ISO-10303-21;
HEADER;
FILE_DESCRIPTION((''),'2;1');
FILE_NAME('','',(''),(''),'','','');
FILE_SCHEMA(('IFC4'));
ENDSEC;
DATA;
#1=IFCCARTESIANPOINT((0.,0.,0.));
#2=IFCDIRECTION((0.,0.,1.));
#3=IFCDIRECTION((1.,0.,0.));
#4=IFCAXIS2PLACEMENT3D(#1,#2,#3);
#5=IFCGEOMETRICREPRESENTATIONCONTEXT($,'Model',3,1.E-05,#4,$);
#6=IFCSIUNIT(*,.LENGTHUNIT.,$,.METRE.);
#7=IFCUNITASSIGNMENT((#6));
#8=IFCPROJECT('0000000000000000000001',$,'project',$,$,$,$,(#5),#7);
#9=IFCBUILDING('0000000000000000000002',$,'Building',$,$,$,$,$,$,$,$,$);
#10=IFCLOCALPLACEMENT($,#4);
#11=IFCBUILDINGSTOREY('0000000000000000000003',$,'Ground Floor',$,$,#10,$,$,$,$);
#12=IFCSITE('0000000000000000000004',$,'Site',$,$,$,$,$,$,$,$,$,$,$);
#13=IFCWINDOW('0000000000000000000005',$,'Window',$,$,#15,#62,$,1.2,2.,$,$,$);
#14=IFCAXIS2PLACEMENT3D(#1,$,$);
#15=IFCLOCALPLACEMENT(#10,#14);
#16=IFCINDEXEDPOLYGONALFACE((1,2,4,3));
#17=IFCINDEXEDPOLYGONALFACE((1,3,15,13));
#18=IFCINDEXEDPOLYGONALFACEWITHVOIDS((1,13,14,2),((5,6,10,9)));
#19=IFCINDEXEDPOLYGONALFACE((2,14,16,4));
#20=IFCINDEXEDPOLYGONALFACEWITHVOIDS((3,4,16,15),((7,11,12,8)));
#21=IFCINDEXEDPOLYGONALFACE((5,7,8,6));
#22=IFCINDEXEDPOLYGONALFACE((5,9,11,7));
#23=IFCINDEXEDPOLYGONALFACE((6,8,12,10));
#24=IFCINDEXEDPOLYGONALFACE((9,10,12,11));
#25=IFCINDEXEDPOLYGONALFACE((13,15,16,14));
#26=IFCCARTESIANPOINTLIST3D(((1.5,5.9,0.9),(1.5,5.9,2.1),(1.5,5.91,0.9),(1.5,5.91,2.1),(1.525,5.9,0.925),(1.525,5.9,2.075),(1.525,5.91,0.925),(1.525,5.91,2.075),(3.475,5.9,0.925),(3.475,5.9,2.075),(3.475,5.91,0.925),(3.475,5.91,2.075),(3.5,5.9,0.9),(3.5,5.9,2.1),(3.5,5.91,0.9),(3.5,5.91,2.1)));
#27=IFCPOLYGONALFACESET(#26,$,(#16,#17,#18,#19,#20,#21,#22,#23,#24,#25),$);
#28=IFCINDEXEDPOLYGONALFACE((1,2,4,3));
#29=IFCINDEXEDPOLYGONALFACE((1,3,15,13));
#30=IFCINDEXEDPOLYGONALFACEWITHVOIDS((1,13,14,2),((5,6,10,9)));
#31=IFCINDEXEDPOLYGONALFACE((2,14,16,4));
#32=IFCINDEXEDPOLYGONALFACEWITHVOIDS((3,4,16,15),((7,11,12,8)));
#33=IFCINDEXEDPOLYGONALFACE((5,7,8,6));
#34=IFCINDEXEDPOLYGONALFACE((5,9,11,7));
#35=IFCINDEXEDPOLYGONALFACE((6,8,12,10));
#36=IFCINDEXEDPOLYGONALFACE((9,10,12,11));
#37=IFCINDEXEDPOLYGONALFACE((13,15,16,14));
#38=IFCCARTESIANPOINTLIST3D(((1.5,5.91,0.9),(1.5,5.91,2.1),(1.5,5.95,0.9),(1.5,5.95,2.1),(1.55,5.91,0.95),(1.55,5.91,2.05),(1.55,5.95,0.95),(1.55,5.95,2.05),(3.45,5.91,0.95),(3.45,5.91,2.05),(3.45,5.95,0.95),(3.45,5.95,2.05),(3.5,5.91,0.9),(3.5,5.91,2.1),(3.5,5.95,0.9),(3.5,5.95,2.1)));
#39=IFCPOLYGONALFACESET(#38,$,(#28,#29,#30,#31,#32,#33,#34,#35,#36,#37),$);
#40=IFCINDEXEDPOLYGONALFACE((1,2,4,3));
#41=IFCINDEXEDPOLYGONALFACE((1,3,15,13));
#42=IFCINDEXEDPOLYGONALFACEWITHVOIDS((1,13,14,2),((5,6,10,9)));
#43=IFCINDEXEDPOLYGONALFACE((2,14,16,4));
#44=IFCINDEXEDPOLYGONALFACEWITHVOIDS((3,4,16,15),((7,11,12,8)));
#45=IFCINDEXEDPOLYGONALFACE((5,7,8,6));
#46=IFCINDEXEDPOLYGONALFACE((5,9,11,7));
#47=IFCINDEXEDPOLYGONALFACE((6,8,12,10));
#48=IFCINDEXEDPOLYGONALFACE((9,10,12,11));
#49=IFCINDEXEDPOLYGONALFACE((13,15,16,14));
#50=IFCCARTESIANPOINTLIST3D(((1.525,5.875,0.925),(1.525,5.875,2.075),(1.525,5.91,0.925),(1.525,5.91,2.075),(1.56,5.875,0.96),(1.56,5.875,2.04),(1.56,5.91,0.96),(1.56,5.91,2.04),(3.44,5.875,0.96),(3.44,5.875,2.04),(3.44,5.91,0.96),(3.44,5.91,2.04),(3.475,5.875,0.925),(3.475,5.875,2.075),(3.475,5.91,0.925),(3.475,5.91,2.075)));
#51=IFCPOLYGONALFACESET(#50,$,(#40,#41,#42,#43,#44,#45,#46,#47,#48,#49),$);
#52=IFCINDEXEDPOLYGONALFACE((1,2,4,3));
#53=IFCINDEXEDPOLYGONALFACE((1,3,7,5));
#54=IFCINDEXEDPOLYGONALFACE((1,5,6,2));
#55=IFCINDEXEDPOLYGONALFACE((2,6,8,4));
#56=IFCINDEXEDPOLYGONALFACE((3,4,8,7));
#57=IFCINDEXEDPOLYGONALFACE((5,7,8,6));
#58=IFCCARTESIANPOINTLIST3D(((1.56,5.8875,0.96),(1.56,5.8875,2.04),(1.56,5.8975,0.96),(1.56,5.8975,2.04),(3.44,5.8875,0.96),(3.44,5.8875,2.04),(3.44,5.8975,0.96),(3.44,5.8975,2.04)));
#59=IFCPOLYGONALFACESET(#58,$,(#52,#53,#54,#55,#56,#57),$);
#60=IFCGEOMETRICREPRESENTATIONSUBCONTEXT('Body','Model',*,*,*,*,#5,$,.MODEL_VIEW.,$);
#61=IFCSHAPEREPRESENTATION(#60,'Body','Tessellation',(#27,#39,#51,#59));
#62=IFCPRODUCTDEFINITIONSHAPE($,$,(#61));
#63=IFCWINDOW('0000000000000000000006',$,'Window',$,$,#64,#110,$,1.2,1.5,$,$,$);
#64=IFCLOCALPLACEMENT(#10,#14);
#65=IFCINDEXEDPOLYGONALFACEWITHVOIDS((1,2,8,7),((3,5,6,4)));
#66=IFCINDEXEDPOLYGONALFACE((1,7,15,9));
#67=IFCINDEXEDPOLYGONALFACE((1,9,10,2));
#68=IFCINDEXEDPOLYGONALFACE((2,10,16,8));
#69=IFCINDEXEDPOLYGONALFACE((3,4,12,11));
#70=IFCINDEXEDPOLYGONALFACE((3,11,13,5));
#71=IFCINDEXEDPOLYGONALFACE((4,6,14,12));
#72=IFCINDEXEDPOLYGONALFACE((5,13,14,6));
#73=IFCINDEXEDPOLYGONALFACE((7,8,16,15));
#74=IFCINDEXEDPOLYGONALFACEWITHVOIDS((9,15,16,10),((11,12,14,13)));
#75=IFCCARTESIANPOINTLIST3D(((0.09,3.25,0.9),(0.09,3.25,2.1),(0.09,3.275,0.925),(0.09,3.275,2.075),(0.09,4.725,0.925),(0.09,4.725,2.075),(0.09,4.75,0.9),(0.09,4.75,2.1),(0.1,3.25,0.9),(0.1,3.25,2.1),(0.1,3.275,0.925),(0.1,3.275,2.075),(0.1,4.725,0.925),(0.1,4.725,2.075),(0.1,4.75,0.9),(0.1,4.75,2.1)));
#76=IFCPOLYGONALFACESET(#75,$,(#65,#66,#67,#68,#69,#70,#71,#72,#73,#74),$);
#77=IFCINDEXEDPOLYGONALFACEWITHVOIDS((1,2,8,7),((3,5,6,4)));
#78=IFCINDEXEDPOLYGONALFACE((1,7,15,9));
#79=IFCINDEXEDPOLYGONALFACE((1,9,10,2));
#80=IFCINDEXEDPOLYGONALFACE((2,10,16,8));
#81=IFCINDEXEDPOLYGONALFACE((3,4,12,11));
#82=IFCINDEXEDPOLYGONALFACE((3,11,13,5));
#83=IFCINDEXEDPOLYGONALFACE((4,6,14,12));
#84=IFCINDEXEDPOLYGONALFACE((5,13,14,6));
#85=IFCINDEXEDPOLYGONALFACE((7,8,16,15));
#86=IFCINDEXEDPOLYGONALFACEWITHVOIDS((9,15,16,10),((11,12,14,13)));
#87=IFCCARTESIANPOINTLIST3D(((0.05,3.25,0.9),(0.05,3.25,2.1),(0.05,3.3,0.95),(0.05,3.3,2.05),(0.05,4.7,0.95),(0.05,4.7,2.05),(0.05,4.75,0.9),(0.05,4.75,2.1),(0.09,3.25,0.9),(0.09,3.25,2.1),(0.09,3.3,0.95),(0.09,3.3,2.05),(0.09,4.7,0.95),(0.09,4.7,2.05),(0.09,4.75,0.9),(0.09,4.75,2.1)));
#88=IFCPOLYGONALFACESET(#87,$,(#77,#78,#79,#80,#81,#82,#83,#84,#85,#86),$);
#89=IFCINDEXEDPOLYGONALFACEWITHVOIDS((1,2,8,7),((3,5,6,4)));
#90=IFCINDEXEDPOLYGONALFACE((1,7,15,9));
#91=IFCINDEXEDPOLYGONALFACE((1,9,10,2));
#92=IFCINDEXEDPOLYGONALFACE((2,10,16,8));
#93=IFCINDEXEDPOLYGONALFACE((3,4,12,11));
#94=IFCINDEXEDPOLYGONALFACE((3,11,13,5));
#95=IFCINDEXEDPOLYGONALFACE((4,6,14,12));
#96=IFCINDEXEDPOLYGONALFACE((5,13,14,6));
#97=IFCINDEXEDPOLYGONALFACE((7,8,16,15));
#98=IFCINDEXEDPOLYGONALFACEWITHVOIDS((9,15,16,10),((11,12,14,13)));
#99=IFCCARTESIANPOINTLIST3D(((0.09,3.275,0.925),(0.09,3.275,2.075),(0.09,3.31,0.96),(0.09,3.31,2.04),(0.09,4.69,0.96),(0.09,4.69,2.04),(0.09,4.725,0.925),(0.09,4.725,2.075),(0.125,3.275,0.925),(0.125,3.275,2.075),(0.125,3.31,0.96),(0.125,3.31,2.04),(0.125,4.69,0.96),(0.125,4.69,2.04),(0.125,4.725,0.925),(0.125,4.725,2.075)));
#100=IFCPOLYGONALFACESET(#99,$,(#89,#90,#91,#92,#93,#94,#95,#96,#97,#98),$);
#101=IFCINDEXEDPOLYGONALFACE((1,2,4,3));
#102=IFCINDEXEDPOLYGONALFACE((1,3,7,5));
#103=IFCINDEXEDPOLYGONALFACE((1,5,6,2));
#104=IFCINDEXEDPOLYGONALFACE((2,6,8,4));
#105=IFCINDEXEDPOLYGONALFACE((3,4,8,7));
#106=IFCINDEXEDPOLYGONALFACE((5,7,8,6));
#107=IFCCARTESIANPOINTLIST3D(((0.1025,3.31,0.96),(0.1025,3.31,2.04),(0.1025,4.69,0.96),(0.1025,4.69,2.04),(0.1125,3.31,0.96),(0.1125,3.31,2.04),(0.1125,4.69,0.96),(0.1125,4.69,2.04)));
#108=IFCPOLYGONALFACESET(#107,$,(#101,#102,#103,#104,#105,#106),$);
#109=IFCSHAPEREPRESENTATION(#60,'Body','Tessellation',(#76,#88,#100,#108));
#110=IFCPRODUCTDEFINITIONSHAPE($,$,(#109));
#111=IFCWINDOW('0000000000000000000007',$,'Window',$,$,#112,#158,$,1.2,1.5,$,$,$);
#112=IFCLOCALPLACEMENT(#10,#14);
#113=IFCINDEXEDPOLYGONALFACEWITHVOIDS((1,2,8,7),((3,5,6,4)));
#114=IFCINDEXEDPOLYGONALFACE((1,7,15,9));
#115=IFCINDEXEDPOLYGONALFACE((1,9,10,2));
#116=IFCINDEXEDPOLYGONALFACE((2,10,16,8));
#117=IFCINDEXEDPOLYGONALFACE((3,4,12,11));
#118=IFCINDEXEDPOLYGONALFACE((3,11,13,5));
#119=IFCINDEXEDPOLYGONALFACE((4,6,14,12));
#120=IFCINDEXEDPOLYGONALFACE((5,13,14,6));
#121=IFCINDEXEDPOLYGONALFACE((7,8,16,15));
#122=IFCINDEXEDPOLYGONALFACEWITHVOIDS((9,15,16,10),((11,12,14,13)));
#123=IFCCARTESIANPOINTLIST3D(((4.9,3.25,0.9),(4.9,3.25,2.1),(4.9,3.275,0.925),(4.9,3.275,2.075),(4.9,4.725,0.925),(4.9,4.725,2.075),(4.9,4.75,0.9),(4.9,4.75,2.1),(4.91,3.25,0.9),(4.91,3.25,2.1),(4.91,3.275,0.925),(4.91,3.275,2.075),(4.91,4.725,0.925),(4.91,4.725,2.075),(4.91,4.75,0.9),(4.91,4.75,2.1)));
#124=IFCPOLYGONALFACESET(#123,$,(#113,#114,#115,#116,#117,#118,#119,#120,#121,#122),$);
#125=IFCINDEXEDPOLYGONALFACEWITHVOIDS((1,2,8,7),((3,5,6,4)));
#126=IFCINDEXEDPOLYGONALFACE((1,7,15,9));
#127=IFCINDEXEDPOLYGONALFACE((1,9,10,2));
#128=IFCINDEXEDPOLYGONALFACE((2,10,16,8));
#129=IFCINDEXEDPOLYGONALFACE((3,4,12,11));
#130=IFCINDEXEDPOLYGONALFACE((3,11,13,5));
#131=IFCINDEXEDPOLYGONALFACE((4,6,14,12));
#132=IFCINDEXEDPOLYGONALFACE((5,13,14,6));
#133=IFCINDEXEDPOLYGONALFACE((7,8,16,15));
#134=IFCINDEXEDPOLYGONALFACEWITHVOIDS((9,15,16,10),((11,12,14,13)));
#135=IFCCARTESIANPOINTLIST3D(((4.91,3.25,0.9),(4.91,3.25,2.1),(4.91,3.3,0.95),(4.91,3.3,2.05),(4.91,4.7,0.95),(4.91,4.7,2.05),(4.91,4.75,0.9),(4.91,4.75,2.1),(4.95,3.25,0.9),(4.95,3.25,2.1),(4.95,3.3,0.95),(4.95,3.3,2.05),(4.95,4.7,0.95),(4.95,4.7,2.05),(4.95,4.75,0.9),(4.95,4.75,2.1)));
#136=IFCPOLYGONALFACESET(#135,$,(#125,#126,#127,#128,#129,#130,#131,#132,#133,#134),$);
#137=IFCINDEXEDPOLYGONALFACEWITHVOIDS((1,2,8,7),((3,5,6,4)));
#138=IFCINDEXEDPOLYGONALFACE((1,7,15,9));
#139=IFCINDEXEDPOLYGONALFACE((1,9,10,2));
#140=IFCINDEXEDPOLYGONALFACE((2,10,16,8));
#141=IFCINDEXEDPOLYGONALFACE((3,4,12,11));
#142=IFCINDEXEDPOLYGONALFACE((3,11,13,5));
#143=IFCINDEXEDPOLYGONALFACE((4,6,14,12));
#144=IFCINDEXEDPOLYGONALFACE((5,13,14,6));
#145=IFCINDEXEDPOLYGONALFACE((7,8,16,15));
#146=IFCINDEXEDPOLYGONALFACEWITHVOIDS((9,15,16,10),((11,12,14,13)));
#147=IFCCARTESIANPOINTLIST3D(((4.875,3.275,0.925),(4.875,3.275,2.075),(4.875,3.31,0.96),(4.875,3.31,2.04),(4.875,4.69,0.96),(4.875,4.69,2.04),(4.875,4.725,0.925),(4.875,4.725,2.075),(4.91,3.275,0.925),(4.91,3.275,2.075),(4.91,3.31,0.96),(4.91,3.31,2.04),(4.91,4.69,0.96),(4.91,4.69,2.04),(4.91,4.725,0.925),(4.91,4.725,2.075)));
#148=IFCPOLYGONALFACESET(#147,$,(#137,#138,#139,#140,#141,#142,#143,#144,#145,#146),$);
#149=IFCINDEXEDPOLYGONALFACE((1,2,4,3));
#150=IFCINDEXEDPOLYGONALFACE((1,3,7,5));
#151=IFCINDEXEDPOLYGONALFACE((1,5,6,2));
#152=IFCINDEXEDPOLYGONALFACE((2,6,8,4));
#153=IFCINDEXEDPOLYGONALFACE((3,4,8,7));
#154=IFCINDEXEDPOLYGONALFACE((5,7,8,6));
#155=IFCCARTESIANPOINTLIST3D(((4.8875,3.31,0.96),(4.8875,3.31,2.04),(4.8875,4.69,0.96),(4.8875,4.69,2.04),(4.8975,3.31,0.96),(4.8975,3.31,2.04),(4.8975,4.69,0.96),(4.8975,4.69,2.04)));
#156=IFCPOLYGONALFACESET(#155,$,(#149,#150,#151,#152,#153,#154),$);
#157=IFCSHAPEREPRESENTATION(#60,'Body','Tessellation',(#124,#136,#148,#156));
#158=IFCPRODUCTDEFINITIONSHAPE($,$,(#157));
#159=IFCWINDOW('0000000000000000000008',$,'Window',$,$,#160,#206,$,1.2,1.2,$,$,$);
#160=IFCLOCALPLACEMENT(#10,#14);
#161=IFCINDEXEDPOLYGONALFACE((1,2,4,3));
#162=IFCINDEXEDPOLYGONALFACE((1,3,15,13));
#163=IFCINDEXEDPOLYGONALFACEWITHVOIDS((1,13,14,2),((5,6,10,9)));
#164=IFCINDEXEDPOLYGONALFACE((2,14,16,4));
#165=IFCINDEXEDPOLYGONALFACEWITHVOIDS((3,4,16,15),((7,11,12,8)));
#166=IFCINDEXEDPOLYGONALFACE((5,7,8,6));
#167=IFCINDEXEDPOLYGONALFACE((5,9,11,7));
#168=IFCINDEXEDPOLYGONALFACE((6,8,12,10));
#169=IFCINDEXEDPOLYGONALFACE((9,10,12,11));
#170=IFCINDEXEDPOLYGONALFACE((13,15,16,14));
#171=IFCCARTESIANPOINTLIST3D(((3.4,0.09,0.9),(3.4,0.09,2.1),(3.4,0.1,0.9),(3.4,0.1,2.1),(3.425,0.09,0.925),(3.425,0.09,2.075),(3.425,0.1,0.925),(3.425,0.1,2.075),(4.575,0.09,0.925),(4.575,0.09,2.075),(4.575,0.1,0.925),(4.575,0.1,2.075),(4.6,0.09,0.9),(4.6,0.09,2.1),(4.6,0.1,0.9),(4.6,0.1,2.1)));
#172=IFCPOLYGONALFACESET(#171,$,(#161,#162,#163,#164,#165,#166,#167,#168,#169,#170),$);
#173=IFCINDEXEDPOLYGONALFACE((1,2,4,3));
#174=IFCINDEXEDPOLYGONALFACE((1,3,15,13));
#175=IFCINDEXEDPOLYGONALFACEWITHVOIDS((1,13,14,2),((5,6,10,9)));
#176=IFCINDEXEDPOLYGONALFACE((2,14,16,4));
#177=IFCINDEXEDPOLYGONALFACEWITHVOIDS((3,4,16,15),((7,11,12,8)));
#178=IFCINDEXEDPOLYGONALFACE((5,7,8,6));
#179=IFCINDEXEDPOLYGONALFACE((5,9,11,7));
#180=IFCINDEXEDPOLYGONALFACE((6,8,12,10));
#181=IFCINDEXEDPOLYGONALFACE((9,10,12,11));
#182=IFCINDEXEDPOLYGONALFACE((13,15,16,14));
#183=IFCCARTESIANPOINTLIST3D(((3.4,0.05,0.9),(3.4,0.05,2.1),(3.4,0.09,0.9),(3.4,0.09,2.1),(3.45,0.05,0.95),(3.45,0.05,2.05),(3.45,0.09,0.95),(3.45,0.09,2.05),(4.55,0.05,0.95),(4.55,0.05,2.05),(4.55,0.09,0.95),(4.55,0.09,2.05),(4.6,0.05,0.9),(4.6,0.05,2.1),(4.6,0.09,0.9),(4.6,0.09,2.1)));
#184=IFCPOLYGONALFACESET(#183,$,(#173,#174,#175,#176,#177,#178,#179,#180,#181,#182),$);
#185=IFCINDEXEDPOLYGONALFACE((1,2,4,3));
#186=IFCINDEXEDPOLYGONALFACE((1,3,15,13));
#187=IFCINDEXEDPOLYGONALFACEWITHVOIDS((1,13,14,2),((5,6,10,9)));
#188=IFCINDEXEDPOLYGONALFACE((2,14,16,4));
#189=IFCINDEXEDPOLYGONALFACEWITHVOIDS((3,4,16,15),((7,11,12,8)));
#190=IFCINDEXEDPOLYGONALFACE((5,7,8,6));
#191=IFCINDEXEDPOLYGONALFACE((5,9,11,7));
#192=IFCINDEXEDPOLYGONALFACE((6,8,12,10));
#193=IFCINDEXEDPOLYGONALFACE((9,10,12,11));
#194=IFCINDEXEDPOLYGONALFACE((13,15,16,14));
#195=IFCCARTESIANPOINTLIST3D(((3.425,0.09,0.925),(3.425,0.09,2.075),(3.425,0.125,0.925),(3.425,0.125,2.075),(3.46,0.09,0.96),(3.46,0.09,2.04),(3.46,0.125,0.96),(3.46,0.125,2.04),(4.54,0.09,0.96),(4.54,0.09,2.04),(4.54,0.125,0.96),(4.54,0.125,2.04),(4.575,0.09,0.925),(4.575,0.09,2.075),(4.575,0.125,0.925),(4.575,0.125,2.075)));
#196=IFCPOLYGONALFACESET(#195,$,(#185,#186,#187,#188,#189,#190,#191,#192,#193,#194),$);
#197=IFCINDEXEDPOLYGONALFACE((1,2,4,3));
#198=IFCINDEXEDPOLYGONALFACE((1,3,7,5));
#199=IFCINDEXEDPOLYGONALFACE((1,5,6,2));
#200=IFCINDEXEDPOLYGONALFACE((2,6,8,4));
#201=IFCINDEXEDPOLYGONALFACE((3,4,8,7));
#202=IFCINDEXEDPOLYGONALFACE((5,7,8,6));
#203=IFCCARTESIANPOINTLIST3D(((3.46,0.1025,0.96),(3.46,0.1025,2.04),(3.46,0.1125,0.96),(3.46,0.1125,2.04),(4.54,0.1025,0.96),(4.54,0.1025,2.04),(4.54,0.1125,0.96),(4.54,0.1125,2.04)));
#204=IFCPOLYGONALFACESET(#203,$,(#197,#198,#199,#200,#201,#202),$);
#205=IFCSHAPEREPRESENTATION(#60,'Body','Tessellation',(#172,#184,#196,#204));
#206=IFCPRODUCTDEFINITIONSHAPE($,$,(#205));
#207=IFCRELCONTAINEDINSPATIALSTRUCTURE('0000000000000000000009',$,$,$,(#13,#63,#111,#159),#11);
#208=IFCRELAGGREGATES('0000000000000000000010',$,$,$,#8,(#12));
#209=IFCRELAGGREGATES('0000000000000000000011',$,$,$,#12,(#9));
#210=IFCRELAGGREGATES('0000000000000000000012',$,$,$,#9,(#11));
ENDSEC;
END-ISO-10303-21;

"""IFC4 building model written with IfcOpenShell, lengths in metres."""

from ifc_helpers import new_model, si_unit, frame, origin_with_axes, place, context, subcontext, project, spatial, line, indexed_curve, outline, extrude, element, save


model = new_model("IFC4")

# Units and contexts
model_context = context("Model", 3, precision=1e-05, world=origin_with_axes())
body_context = subcontext(model_context, "Body", "Model", "MODEL_VIEW")
ifc_project = project(units=[si_unit("LENGTHUNIT", "METRE")], contexts=[model_context])

# Site, building, storey
site = spatial("IfcSite", under=ifc_project, Name="Site")
building = spatial("IfcBuilding", under=site, Name="Building")
storey_placement = place(None, origin_with_axes())
storey = spatial("IfcBuildingStorey", under=building, at=storey_placement, Name="Ground Floor")

# Windows
window_1_placement = place(storey_placement, frame((3.5, 6.0, 0.9), z_axis=(0.0, 0.0, 1.0), x_axis=(-1.0, 0.0, 0.0)))
element("IfcWindow", 1, at=window_1_placement, inside=storey, Name="Window", OverallHeight=1.2, OverallWidth=2.0, context=body_context, shape_type="SweptSolid", body=[
    extrude(outline(indexed_curve([(0.0, 0.0), (2.0, 0.0), (2.0, 1.2), (0.0, 1.2)], segments=[line(1, 2, 3, 4, 1)]), holes=[indexed_curve([(0.025, 0.025), (1.975, 0.025), (1.975, 1.175), (0.025, 1.175)], segments=[line(1, 2, 3, 4, 1)])]), frame((0.0, 0.09, 0.0), z_axis=(0.0, -1.0, 0.0), x_axis=(1.0, 0.0, 0.0)), (0.0, 0.0, -1.0), 0.01),
    extrude(outline(indexed_curve([(0.0, 0.0), (2.0, 0.0), (2.0, 1.2), (0.0, 1.2)], segments=[line(1, 2, 3, 4, 1)]), holes=[indexed_curve([(0.05, 0.05), (1.95, 0.05), (1.95, 1.15), (0.05, 1.15)], segments=[line(1, 2, 3, 4, 1)])]), frame((0.0, 0.05, 0.0), z_axis=(0.0, -1.0, 0.0), x_axis=(1.0, 0.0, 0.0)), (0.0, 0.0, -1.0), 0.04),
    extrude(outline(indexed_curve([(0.0, 0.0), (1.95, 0.0), (1.95, 1.15), (0.0, 1.15)], segments=[line(1, 2, 3, 4, 1)]), holes=[indexed_curve([(0.035, 0.035), (1.915, 0.035), (1.915, 1.115), (0.035, 1.115)], segments=[line(1, 2, 3, 4, 1)])]), frame((0.025, 0.09, 0.025), z_axis=(0.0, -1.0, 0.0), x_axis=(1.0, 0.0, 0.0)), (0.0, 0.0, -1.0), 0.035),
    extrude(outline(indexed_curve([(0.035, 0.035), (1.915, 0.035), (1.915, 1.115), (0.035, 1.115)], segments=[line(1, 2, 3, 4, 1)])), frame((0.025, 0.1025, 0.025), z_axis=(0.0, -1.0, 0.0), x_axis=(1.0, 0.0, 0.0)), (0.0, 0.0, -1.0), 0.01),
])
for number, where, z_axis, x_axis, name in (
    (2, (0.0, 4.75, 0.9), (0.0, 0.0, 1.0), (0.0, -1.0, 0.0), "Window"),
    (3, (5.0, 3.25, 0.9), (0.0, 0.0, 1.0), (0.0, 1.0, 0.0), "Window"),
):
    element("IfcWindow", number, at=place(storey_placement, frame(where, z_axis=z_axis, x_axis=x_axis)), inside=storey, Name=name, OverallHeight=1.2, OverallWidth=1.5, context=body_context, shape_type="SweptSolid", body=[
        extrude(outline(indexed_curve([(0.0, 0.0), (1.5, 0.0), (1.5, 1.2), (0.0, 1.2)], segments=[line(1, 2, 3, 4, 1)]), holes=[indexed_curve([(0.025, 0.025), (1.475, 0.025), (1.475, 1.175), (0.025, 1.175)], segments=[line(1, 2, 3, 4, 1)])]), frame((0.0, 0.09, 0.0), z_axis=(0.0, -1.0, 0.0), x_axis=(1.0, 0.0, 0.0)), (0.0, 0.0, -1.0), 0.01),
        extrude(outline(indexed_curve([(0.0, 0.0), (1.5, 0.0), (1.5, 1.2), (0.0, 1.2)], segments=[line(1, 2, 3, 4, 1)]), holes=[indexed_curve([(0.05, 0.05), (1.45, 0.05), (1.45, 1.15), (0.05, 1.15)], segments=[line(1, 2, 3, 4, 1)])]), frame((0.0, 0.05, 0.0), z_axis=(0.0, -1.0, 0.0), x_axis=(1.0, 0.0, 0.0)), (0.0, 0.0, -1.0), 0.04),
        extrude(outline(indexed_curve([(0.0, 0.0), (1.45, 0.0), (1.45, 1.15), (0.0, 1.15)], segments=[line(1, 2, 3, 4, 1)]), holes=[indexed_curve([(0.035, 0.035), (1.415, 0.035), (1.415, 1.115), (0.035, 1.115)], segments=[line(1, 2, 3, 4, 1)])]), frame((0.025, 0.09, 0.025), z_axis=(0.0, -1.0, 0.0), x_axis=(1.0, 0.0, 0.0)), (0.0, 0.0, -1.0), 0.035),
        extrude(outline(indexed_curve([(0.035, 0.035), (1.415, 0.035), (1.415, 1.115), (0.035, 1.115)], segments=[line(1, 2, 3, 4, 1)])), frame((0.025, 0.1025, 0.025), z_axis=(0.0, -1.0, 0.0), x_axis=(1.0, 0.0, 0.0)), (0.0, 0.0, -1.0), 0.01),
    ])
window_2_placement = place(storey_placement, frame((3.4, 0.0, 0.9), z_axis=(0.0, 0.0, 1.0), x_axis=(1.0, 0.0, 0.0)))
element("IfcWindow", 4, at=window_2_placement, inside=storey, Name="Window", OverallHeight=1.2, OverallWidth=1.2, context=body_context, shape_type="SweptSolid", body=[
    extrude(outline(indexed_curve([(0.0, 0.0), (1.2, 0.0), (1.2, 1.2), (0.0, 1.2)], segments=[line(1, 2, 3, 4, 1)]), holes=[indexed_curve([(0.025, 0.025), (1.175, 0.025), (1.175, 1.175), (0.025, 1.175)], segments=[line(1, 2, 3, 4, 1)])]), frame((0.0, 0.09, 0.0), z_axis=(0.0, -1.0, 0.0), x_axis=(1.0, 0.0, 0.0)), (0.0, 0.0, -1.0), 0.01),
    extrude(outline(indexed_curve([(0.0, 0.0), (1.2, 0.0), (1.2, 1.2), (0.0, 1.2)], segments=[line(1, 2, 3, 4, 1)]), holes=[indexed_curve([(0.05, 0.05), (1.15, 0.05), (1.15, 1.15), (0.05, 1.15)], segments=[line(1, 2, 3, 4, 1)])]), frame((0.0, 0.05, 0.0), z_axis=(0.0, -1.0, 0.0), x_axis=(1.0, 0.0, 0.0)), (0.0, 0.0, -1.0), 0.04),
    extrude(outline(indexed_curve([(0.0, 0.0), (1.15, 0.0), (1.15, 1.15), (0.0, 1.15)], segments=[line(1, 2, 3, 4, 1)]), holes=[indexed_curve([(0.035, 0.035), (1.115, 0.035), (1.115, 1.115), (0.035, 1.115)], segments=[line(1, 2, 3, 4, 1)])]), frame((0.025, 0.09, 0.025), z_axis=(0.0, -1.0, 0.0), x_axis=(1.0, 0.0, 0.0)), (0.0, 0.0, -1.0), 0.035),
    extrude(outline(indexed_curve([(0.035, 0.035), (1.115, 0.035), (1.115, 1.115), (0.035, 1.115)], segments=[line(1, 2, 3, 4, 1)])), frame((0.025, 0.1025, 0.025), z_axis=(0.0, -1.0, 0.0), x_axis=(1.0, 0.0, 0.0)), (0.0, 0.0, -1.0), 0.01),
])

save(model, "model.ifc")
